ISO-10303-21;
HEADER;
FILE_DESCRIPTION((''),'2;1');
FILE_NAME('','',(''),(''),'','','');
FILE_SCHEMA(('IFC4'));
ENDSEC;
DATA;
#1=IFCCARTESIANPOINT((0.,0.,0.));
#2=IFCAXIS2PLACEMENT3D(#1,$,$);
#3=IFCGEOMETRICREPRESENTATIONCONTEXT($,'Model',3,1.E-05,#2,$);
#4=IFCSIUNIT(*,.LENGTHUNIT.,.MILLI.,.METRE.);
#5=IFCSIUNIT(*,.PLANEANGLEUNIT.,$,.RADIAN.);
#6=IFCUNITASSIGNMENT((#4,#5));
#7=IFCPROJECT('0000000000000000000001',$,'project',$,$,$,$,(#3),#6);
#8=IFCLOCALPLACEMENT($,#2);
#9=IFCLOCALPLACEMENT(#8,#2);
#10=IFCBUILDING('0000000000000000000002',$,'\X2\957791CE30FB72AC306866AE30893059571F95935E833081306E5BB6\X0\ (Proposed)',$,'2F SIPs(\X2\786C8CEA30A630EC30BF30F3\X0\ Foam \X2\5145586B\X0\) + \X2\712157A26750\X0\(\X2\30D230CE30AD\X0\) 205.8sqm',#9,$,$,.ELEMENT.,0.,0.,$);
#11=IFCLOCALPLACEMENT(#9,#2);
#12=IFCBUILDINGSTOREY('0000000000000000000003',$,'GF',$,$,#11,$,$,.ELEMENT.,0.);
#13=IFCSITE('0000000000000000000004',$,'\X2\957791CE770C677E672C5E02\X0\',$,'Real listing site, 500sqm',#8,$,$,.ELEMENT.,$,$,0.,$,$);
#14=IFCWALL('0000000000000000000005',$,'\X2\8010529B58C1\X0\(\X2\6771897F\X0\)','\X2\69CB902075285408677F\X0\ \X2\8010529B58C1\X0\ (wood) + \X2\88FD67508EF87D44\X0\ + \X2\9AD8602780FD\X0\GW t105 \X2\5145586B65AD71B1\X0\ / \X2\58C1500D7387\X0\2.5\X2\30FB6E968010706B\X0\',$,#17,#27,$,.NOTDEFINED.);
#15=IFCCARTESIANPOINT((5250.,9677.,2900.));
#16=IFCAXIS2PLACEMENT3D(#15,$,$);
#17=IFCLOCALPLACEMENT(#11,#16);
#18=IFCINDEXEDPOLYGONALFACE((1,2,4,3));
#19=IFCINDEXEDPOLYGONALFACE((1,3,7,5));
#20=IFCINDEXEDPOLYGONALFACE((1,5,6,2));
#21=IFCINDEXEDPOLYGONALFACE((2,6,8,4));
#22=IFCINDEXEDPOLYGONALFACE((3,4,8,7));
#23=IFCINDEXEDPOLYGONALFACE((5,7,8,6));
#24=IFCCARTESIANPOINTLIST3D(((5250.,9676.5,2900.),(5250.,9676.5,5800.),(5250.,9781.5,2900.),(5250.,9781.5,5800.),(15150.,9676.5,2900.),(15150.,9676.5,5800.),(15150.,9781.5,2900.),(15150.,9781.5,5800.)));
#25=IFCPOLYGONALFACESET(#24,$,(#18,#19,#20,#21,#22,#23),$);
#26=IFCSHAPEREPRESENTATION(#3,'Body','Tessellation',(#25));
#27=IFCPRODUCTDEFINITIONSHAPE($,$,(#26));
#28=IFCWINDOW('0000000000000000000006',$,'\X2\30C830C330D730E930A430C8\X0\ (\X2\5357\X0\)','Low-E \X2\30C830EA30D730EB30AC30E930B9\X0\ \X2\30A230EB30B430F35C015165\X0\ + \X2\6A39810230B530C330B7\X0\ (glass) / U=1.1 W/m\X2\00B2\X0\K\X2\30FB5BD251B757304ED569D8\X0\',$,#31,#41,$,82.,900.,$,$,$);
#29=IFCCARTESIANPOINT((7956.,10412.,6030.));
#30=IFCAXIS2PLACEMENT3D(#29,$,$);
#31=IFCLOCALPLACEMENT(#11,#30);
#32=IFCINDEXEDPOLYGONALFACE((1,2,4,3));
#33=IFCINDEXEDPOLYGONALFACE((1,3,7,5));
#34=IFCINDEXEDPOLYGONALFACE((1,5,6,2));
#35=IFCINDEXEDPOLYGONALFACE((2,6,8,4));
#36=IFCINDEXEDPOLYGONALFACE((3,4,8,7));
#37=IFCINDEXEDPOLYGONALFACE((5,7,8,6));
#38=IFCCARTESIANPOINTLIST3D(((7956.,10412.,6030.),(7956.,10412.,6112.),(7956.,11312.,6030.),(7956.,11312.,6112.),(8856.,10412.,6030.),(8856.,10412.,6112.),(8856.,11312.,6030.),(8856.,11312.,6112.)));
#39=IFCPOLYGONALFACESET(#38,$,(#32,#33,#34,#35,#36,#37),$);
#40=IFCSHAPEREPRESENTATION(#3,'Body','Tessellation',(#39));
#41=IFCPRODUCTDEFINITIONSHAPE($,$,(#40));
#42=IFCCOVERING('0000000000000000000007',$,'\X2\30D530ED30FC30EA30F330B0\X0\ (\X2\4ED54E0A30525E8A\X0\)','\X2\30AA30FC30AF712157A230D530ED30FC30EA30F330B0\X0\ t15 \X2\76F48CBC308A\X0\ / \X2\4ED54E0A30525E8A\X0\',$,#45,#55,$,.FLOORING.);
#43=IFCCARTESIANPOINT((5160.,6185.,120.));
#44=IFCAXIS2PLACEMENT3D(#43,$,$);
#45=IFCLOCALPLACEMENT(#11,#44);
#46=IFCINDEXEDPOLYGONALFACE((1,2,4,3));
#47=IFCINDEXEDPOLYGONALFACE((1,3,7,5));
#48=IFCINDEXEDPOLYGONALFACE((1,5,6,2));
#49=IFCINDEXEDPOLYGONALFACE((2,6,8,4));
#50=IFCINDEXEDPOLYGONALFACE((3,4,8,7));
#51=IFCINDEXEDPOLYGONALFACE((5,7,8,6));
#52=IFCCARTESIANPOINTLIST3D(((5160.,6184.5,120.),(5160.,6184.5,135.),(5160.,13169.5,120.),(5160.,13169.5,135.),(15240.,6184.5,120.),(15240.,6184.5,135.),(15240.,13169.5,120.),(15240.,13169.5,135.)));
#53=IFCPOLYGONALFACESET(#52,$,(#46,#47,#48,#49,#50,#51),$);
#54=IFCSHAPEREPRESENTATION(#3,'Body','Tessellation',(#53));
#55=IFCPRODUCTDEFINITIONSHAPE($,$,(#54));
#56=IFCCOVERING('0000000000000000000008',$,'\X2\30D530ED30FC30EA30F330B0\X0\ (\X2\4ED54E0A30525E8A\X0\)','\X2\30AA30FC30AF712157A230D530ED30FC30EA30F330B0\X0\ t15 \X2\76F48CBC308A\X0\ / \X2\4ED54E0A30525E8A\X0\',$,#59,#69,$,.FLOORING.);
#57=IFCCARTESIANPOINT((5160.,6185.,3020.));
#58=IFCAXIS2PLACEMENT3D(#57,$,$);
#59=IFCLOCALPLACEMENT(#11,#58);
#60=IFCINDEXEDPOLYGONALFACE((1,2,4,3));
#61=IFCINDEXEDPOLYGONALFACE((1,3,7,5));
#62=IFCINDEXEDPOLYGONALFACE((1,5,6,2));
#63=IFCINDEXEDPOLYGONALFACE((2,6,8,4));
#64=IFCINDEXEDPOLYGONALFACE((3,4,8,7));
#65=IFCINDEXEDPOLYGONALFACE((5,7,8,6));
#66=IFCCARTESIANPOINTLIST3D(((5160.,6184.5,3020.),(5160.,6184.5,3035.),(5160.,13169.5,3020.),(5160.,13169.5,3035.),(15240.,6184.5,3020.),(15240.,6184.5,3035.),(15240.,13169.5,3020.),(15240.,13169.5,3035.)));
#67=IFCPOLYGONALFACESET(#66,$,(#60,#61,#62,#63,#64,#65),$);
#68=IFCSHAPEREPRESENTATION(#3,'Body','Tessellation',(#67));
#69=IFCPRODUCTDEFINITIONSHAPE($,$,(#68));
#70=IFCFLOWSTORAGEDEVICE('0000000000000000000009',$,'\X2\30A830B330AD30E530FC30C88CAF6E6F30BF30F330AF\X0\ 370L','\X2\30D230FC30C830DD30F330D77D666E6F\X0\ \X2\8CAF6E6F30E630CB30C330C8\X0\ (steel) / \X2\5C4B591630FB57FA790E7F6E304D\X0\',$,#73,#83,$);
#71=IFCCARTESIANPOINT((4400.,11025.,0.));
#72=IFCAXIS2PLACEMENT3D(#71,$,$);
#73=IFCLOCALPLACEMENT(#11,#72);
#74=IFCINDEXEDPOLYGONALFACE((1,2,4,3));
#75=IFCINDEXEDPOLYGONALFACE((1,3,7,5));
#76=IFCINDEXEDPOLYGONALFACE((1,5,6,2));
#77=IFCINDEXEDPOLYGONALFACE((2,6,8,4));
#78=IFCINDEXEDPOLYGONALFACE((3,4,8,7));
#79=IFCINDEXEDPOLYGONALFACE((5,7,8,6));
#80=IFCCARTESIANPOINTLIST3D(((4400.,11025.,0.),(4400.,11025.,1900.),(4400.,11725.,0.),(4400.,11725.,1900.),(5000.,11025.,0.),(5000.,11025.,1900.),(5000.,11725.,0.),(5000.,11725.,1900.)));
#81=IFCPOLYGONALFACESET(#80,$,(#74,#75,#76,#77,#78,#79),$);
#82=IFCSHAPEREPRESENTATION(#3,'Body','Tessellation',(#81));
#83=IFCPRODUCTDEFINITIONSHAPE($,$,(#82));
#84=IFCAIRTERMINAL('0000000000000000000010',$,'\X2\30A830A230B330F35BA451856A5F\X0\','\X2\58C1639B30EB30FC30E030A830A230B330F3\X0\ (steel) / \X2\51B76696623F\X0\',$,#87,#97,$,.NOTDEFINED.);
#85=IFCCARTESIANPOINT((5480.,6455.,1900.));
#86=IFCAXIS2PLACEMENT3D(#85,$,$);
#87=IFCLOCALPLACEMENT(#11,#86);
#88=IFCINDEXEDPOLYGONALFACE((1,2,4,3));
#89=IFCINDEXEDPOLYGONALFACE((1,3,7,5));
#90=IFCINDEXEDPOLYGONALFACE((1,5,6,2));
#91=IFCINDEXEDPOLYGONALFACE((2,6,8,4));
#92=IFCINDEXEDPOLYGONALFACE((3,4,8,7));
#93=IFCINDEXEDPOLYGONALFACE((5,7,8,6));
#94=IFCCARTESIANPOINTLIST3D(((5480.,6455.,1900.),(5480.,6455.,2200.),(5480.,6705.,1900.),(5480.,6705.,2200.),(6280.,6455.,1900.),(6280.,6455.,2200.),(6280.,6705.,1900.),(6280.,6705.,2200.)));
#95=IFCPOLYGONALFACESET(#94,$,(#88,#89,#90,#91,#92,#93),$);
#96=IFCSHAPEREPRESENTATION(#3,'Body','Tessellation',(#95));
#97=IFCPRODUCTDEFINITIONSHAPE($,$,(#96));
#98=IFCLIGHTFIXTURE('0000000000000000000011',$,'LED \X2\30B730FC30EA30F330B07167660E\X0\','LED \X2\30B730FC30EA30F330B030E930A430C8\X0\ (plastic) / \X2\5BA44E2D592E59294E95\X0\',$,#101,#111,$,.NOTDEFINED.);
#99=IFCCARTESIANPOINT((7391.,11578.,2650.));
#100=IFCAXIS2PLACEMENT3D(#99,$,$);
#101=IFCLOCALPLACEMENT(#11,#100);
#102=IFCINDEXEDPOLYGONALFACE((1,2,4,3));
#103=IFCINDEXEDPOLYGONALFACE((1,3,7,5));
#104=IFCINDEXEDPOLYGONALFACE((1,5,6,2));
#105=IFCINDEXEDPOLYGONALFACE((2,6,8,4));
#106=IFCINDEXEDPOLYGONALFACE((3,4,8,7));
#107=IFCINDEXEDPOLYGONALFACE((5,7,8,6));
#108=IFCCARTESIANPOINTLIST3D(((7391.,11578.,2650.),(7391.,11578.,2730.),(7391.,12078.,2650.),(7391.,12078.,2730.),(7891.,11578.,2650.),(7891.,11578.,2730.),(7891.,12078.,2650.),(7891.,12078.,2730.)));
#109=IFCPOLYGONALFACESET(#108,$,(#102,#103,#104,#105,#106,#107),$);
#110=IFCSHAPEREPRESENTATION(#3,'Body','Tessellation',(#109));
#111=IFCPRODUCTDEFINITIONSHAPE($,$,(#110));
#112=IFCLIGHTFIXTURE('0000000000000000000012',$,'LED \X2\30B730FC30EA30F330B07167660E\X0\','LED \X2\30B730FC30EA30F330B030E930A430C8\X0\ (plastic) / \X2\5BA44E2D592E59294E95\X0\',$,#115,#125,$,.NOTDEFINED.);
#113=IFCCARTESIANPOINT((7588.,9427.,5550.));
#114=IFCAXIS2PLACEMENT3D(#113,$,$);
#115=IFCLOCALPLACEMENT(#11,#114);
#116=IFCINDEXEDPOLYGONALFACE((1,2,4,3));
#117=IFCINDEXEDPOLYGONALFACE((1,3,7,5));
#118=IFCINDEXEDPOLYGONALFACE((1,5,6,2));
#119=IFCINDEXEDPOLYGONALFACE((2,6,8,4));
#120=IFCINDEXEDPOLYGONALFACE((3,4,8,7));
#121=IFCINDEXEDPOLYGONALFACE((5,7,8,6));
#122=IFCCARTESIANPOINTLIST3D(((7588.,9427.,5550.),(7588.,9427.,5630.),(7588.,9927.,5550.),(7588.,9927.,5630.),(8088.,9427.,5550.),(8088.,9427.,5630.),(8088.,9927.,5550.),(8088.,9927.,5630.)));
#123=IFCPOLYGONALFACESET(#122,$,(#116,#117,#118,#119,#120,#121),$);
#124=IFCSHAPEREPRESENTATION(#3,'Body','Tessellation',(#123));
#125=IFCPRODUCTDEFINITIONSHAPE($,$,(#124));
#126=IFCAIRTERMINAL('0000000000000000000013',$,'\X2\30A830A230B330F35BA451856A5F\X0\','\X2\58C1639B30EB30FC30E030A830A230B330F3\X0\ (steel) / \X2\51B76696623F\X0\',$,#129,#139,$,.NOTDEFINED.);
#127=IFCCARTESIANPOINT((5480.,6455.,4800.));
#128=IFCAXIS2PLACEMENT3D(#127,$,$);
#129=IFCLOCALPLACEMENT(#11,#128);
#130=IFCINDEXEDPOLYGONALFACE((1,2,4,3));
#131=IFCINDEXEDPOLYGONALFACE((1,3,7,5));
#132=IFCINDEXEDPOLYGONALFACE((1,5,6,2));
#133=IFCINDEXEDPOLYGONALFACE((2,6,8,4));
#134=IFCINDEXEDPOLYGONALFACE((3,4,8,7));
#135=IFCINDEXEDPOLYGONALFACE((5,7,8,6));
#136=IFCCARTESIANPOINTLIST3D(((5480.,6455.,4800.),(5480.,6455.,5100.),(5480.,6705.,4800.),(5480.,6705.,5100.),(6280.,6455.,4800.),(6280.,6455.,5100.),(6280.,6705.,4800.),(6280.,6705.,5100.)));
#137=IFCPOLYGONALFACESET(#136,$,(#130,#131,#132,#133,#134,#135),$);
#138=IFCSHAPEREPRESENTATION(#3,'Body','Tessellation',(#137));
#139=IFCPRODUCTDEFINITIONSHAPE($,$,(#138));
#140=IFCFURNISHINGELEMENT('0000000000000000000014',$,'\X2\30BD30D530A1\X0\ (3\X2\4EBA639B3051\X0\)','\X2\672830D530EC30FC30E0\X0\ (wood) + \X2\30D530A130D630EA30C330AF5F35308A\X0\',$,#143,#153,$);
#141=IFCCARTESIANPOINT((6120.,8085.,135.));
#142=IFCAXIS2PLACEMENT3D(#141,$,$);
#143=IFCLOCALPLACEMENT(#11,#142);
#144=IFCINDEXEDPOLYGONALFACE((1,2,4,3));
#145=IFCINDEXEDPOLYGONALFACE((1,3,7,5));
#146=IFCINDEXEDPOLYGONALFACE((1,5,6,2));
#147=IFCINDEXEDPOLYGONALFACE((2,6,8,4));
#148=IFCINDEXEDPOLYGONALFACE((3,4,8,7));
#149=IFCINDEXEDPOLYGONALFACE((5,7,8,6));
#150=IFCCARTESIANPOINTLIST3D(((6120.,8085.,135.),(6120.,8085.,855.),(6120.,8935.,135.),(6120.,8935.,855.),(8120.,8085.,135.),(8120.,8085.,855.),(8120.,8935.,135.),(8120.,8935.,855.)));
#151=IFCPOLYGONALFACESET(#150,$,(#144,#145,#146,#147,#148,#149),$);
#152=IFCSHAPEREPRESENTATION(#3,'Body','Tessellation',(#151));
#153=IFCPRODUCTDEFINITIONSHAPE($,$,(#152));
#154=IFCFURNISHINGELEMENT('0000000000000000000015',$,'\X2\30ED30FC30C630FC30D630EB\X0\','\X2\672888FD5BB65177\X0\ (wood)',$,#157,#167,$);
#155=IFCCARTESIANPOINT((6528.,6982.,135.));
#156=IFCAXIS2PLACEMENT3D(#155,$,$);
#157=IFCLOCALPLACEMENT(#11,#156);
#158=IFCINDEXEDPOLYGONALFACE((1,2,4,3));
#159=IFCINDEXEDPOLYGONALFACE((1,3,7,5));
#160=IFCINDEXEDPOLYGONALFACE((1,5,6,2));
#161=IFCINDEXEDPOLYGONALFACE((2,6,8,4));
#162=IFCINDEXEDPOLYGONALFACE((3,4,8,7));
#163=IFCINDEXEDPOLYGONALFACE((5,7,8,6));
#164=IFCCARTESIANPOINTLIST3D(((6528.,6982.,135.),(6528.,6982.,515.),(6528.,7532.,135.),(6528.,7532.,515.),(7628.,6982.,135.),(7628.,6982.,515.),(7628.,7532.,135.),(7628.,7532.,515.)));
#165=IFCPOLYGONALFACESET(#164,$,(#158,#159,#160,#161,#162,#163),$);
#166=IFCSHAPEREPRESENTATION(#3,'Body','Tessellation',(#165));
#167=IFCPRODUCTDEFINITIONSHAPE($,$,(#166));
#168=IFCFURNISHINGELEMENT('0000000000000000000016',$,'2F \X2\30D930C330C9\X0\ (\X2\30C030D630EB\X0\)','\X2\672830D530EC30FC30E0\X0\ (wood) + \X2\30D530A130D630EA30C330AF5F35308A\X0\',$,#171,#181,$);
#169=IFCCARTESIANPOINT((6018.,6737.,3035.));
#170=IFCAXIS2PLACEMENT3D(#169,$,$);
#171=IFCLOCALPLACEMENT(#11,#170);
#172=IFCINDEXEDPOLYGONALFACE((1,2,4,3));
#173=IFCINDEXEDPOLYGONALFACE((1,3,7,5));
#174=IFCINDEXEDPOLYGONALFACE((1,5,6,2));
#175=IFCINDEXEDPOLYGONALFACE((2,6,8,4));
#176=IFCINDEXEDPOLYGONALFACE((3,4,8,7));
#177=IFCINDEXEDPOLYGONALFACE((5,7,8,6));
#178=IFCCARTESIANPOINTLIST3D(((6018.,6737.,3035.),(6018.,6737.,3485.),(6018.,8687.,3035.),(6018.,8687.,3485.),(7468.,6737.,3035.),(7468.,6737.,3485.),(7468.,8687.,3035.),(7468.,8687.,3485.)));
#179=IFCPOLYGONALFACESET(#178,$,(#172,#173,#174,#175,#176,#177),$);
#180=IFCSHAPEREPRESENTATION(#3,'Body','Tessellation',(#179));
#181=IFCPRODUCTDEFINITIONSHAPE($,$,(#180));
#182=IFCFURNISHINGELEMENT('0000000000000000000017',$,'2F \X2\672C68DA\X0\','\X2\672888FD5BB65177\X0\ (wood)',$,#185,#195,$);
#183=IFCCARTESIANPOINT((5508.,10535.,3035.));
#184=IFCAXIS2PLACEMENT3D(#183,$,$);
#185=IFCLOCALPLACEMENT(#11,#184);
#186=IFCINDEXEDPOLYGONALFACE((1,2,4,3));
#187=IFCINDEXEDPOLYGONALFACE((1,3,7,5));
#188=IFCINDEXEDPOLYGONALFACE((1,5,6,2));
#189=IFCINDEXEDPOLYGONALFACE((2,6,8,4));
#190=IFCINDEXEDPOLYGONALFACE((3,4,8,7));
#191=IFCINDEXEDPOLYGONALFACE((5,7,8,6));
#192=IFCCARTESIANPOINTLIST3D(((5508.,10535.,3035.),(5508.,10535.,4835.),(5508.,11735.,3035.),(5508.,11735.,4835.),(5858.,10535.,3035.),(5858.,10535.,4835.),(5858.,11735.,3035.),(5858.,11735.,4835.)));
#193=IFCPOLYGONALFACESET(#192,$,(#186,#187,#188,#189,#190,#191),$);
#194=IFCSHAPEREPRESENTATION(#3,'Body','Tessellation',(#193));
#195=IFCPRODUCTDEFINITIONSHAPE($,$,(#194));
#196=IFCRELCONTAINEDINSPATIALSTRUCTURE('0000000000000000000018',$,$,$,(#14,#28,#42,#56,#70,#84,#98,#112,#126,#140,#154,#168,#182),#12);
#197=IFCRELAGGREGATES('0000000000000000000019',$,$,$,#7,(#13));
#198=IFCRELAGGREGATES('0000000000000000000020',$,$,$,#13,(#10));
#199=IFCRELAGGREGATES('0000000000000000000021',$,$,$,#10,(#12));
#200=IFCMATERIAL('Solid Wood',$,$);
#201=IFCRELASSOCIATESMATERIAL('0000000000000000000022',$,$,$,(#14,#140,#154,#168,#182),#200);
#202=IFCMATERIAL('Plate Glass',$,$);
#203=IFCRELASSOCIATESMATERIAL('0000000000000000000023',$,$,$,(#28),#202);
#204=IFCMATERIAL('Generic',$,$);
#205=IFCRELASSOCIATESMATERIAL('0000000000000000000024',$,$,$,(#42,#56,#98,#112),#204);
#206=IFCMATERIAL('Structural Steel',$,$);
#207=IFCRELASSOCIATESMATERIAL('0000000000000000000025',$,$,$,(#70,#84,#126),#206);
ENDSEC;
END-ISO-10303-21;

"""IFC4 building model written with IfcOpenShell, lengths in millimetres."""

from ifc_helpers import new_model, si_unit, frame, frame_2d, origin, place, context, project, spatial, rectangle, extrude, material, element, save


model = new_model("IFC4")

# Units and contexts
model_context = context("Model", 3, precision=1e-05, world=origin())
ifc_project = project(units=[si_unit("LENGTHUNIT", "METRE", prefix="MILLI"), si_unit("PLANEANGLEUNIT", "RADIAN")], contexts=[model_context])

# Site, building, storey
site_placement = place(None, origin())
site = spatial("IfcSite", under=ifc_project, at=site_placement, Name="長野県松本市", ObjectType="Real listing site, 500sqm", CompositionType="ELEMENT", RefElevation=0.0)
building_placement = place(site_placement, origin())
building = spatial("IfcBuilding", under=site, at=building_placement, Name="長野・犬と暮らす土間広めの家 (Proposed)", ObjectType="2F SIPs(硬質ウレタン Foam 充填) + 無垢材(ヒノキ) 205.8sqm", CompositionType="ELEMENT", ElevationOfRefHeight=0.0, ElevationOfTerrain=0.0)
storey_placement = place(building_placement, origin())
storey = spatial("IfcBuildingStorey", under=building, at=storey_placement, Name="GF", CompositionType="ELEMENT", Elevation=0.0)

# Shared definitions
ifc_material_1 = material(Name="Solid Wood")

# Wall
wall_1_placement = place(storey_placement, frame((5250.0, 9677.0, 2900.0)))
element("IfcWall", 1, at=wall_1_placement, inside=storey, material=ifc_material_1, Name="耐力壁(東西)", Description="構造用合板 耐力壁 (wood) + 製材軸組 + 高性能GW t105 充填断熱 / 壁倍率2.5・準耐火", PredefinedType="NOTDEFINED", context=model_context, shape_type="SweptSolid", body=[
    extrude(rectangle(XDim=9900.0, YDim=105.0, at=frame_2d((4950.0, 52.0))), frame((5250.0, 9677.0, 2900.0)), (0.0, 0.0, 1.0), 2900.0),
])

# Window
ifc_material_2 = material(Name="Plate Glass")
window_placement = place(storey_placement, frame((7956.0, 10412.0, 6030.0)))
element("IfcWindow", 2, at=window_placement, inside=storey, material=ifc_material_2, Name="トップライト (南)", Description="Low-E トリプルガラス アルゴン封入 + 樹脂サッシ (glass) / U=1.1 W/m²K・寒冷地仕様", OverallHeight=82.0, OverallWidth=900.0, context=model_context, shape_type="SweptSolid", body=[
    extrude(rectangle(XDim=900.0, YDim=900.0, at=frame_2d((450.0, 450.0))), frame((7956.0, 10412.0, 6030.0)), (0.0, 0.0, 1.0), 82.0),
])

# Coverings
ifc_material_3 = material(Name="Generic")
covering_1_placement = place(storey_placement, frame((5160.0, 6185.0, 120.0)))
element("IfcCovering", 3, at=covering_1_placement, inside=storey, material=ifc_material_3, Name="フローリング (仕上げ床)", Description="オーク無垢フローリング t15 直貼り / 仕上げ床", PredefinedType="FLOORING", context=model_context, shape_type="SweptSolid", body=[
    extrude(rectangle(XDim=10080.0, YDim=6985.0, at=frame_2d((5040.0, 3492.0))), frame((5160.0, 6185.0, 120.0)), (0.0, 0.0, 1.0), 15.0),
])
covering_2_placement = place(storey_placement, frame((5160.0, 6185.0, 3020.0)))
element("IfcCovering", 4, at=covering_2_placement, inside=storey, material=ifc_material_3, Name="フローリング (仕上げ床)", Description="オーク無垢フローリング t15 直貼り / 仕上げ床", PredefinedType="FLOORING", context=model_context, shape_type="SweptSolid", body=[
    extrude(rectangle(XDim=10080.0, YDim=6985.0, at=frame_2d((5040.0, 3492.0))), frame((5160.0, 6185.0, 3020.0)), (0.0, 0.0, 1.0), 15.0),
])

# Flow storage device
ifc_material_4 = material(Name="Structural Steel")
flow_storage_device_placement = place(storey_placement, frame((4400.0, 11025.0, 0.0)))
element("IfcFlowStorageDevice", 5, at=flow_storage_device_placement, inside=storey, material=ifc_material_4, Name="エコキュート貯湯タンク 370L", Description="ヒートポンプ給湯 貯湯ユニット (steel) / 屋外・基礎置き", context=model_context, shape_type="SweptSolid", body=[
    extrude(rectangle(XDim=600.0, YDim=700.0, at=frame_2d((300.0, 350.0))), frame((4400.0, 11025.0, 0.0)), (0.0, 0.0, 1.0), 1900.0),
])

# Air terminal
air_terminal_1_placement = place(storey_placement, frame((5480.0, 6455.0, 1900.0)))
element("IfcAirTerminal", 6, at=air_terminal_1_placement, inside=storey, material=ifc_material_4, Name="エアコン室内機", Description="壁掛ルームエアコン (steel) / 冷暖房", PredefinedType="NOTDEFINED", context=model_context, shape_type="SweptSolid", body=[
    extrude(rectangle(XDim=800.0, YDim=250.0, at=frame_2d((400.0, 125.0))), frame((5480.0, 6455.0, 1900.0)), (0.0, 0.0, 1.0), 300.0),
])

# Light fixtures
light_fixture_1_placement = place(storey_placement, frame((7391.0, 11578.0, 2650.0)))
element("IfcLightFixture", 7, at=light_fixture_1_placement, inside=storey, material=ifc_material_3, Name="LED シーリング照明", Description="LED シーリングライト (plastic) / 室中央天井", PredefinedType="NOTDEFINED", context=model_context, shape_type="SweptSolid", body=[
    extrude(rectangle(XDim=500.0, YDim=500.0, at=frame_2d((250.0, 250.0))), frame((7391.0, 11578.0, 2650.0)), (0.0, 0.0, 1.0), 80.0),
])
light_fixture_2_placement = place(storey_placement, frame((7588.0, 9427.0, 5550.0)))
element("IfcLightFixture", 8, at=light_fixture_2_placement, inside=storey, material=ifc_material_3, Name="LED シーリング照明", Description="LED シーリングライト (plastic) / 室中央天井", PredefinedType="NOTDEFINED", context=model_context, shape_type="SweptSolid", body=[
    extrude(rectangle(XDim=500.0, YDim=500.0, at=frame_2d((250.0, 250.0))), frame((7588.0, 9427.0, 5550.0)), (0.0, 0.0, 1.0), 80.0),
])

# Air terminal
air_terminal_2_placement = place(storey_placement, frame((5480.0, 6455.0, 4800.0)))
element("IfcAirTerminal", 9, at=air_terminal_2_placement, inside=storey, material=ifc_material_4, Name="エアコン室内機", Description="壁掛ルームエアコン (steel) / 冷暖房", PredefinedType="NOTDEFINED", context=model_context, shape_type="SweptSolid", body=[
    extrude(rectangle(XDim=800.0, YDim=250.0, at=frame_2d((400.0, 125.0))), frame((5480.0, 6455.0, 4800.0)), (0.0, 0.0, 1.0), 300.0),
])

# Furnishing elements
furnishing_1_placement = place(storey_placement, frame((6120.0, 8085.0, 135.0)))
element("IfcFurnishingElement", 10, at=furnishing_1_placement, inside=storey, material=ifc_material_1, Name="ソファ (3人掛け)", Description="木フレーム (wood) + ファブリック張り", context=model_context, shape_type="SweptSolid", body=[
    extrude(rectangle(XDim=2000.0, YDim=850.0, at=frame_2d((1000.0, 425.0))), frame((6120.0, 8085.0, 135.0)), (0.0, 0.0, 1.0), 720.0),
])
furnishing_2_placement = place(storey_placement, frame((6528.0, 6982.0, 135.0)))
element("IfcFurnishingElement", 11, at=furnishing_2_placement, inside=storey, material=ifc_material_1, Name="ローテーブル", Description="木製家具 (wood)", context=model_context, shape_type="SweptSolid", body=[
    extrude(rectangle(XDim=1100.0, YDim=550.0, at=frame_2d((550.0, 275.0))), frame((6528.0, 6982.0, 135.0)), (0.0, 0.0, 1.0), 380.0),
])
furnishing_3_placement = place(storey_placement, frame((6018.0, 6737.0, 3035.0)))
element("IfcFurnishingElement", 12, at=furnishing_3_placement, inside=storey, material=ifc_material_1, Name="2F ベッド (ダブル)", Description="木フレーム (wood) + ファブリック張り", context=model_context, shape_type="SweptSolid", body=[
    extrude(rectangle(XDim=1450.0, YDim=1950.0, at=frame_2d((725.0, 975.0))), frame((6018.0, 6737.0, 3035.0)), (0.0, 0.0, 1.0), 450.0),
])
furnishing_4_placement = place(storey_placement, frame((5508.0, 10535.0, 3035.0)))
element("IfcFurnishingElement", 13, at=furnishing_4_placement, inside=storey, material=ifc_material_1, Name="2F 本棚", Description="木製家具 (wood)", context=model_context, shape_type="SweptSolid", body=[
    extrude(rectangle(XDim=350.0, YDim=1200.0, at=frame_2d((175.0, 600.0))), frame((5508.0, 10535.0, 3035.0)), (0.0, 0.0, 1.0), 1800.0),
])

save(model, "model.ifc")
